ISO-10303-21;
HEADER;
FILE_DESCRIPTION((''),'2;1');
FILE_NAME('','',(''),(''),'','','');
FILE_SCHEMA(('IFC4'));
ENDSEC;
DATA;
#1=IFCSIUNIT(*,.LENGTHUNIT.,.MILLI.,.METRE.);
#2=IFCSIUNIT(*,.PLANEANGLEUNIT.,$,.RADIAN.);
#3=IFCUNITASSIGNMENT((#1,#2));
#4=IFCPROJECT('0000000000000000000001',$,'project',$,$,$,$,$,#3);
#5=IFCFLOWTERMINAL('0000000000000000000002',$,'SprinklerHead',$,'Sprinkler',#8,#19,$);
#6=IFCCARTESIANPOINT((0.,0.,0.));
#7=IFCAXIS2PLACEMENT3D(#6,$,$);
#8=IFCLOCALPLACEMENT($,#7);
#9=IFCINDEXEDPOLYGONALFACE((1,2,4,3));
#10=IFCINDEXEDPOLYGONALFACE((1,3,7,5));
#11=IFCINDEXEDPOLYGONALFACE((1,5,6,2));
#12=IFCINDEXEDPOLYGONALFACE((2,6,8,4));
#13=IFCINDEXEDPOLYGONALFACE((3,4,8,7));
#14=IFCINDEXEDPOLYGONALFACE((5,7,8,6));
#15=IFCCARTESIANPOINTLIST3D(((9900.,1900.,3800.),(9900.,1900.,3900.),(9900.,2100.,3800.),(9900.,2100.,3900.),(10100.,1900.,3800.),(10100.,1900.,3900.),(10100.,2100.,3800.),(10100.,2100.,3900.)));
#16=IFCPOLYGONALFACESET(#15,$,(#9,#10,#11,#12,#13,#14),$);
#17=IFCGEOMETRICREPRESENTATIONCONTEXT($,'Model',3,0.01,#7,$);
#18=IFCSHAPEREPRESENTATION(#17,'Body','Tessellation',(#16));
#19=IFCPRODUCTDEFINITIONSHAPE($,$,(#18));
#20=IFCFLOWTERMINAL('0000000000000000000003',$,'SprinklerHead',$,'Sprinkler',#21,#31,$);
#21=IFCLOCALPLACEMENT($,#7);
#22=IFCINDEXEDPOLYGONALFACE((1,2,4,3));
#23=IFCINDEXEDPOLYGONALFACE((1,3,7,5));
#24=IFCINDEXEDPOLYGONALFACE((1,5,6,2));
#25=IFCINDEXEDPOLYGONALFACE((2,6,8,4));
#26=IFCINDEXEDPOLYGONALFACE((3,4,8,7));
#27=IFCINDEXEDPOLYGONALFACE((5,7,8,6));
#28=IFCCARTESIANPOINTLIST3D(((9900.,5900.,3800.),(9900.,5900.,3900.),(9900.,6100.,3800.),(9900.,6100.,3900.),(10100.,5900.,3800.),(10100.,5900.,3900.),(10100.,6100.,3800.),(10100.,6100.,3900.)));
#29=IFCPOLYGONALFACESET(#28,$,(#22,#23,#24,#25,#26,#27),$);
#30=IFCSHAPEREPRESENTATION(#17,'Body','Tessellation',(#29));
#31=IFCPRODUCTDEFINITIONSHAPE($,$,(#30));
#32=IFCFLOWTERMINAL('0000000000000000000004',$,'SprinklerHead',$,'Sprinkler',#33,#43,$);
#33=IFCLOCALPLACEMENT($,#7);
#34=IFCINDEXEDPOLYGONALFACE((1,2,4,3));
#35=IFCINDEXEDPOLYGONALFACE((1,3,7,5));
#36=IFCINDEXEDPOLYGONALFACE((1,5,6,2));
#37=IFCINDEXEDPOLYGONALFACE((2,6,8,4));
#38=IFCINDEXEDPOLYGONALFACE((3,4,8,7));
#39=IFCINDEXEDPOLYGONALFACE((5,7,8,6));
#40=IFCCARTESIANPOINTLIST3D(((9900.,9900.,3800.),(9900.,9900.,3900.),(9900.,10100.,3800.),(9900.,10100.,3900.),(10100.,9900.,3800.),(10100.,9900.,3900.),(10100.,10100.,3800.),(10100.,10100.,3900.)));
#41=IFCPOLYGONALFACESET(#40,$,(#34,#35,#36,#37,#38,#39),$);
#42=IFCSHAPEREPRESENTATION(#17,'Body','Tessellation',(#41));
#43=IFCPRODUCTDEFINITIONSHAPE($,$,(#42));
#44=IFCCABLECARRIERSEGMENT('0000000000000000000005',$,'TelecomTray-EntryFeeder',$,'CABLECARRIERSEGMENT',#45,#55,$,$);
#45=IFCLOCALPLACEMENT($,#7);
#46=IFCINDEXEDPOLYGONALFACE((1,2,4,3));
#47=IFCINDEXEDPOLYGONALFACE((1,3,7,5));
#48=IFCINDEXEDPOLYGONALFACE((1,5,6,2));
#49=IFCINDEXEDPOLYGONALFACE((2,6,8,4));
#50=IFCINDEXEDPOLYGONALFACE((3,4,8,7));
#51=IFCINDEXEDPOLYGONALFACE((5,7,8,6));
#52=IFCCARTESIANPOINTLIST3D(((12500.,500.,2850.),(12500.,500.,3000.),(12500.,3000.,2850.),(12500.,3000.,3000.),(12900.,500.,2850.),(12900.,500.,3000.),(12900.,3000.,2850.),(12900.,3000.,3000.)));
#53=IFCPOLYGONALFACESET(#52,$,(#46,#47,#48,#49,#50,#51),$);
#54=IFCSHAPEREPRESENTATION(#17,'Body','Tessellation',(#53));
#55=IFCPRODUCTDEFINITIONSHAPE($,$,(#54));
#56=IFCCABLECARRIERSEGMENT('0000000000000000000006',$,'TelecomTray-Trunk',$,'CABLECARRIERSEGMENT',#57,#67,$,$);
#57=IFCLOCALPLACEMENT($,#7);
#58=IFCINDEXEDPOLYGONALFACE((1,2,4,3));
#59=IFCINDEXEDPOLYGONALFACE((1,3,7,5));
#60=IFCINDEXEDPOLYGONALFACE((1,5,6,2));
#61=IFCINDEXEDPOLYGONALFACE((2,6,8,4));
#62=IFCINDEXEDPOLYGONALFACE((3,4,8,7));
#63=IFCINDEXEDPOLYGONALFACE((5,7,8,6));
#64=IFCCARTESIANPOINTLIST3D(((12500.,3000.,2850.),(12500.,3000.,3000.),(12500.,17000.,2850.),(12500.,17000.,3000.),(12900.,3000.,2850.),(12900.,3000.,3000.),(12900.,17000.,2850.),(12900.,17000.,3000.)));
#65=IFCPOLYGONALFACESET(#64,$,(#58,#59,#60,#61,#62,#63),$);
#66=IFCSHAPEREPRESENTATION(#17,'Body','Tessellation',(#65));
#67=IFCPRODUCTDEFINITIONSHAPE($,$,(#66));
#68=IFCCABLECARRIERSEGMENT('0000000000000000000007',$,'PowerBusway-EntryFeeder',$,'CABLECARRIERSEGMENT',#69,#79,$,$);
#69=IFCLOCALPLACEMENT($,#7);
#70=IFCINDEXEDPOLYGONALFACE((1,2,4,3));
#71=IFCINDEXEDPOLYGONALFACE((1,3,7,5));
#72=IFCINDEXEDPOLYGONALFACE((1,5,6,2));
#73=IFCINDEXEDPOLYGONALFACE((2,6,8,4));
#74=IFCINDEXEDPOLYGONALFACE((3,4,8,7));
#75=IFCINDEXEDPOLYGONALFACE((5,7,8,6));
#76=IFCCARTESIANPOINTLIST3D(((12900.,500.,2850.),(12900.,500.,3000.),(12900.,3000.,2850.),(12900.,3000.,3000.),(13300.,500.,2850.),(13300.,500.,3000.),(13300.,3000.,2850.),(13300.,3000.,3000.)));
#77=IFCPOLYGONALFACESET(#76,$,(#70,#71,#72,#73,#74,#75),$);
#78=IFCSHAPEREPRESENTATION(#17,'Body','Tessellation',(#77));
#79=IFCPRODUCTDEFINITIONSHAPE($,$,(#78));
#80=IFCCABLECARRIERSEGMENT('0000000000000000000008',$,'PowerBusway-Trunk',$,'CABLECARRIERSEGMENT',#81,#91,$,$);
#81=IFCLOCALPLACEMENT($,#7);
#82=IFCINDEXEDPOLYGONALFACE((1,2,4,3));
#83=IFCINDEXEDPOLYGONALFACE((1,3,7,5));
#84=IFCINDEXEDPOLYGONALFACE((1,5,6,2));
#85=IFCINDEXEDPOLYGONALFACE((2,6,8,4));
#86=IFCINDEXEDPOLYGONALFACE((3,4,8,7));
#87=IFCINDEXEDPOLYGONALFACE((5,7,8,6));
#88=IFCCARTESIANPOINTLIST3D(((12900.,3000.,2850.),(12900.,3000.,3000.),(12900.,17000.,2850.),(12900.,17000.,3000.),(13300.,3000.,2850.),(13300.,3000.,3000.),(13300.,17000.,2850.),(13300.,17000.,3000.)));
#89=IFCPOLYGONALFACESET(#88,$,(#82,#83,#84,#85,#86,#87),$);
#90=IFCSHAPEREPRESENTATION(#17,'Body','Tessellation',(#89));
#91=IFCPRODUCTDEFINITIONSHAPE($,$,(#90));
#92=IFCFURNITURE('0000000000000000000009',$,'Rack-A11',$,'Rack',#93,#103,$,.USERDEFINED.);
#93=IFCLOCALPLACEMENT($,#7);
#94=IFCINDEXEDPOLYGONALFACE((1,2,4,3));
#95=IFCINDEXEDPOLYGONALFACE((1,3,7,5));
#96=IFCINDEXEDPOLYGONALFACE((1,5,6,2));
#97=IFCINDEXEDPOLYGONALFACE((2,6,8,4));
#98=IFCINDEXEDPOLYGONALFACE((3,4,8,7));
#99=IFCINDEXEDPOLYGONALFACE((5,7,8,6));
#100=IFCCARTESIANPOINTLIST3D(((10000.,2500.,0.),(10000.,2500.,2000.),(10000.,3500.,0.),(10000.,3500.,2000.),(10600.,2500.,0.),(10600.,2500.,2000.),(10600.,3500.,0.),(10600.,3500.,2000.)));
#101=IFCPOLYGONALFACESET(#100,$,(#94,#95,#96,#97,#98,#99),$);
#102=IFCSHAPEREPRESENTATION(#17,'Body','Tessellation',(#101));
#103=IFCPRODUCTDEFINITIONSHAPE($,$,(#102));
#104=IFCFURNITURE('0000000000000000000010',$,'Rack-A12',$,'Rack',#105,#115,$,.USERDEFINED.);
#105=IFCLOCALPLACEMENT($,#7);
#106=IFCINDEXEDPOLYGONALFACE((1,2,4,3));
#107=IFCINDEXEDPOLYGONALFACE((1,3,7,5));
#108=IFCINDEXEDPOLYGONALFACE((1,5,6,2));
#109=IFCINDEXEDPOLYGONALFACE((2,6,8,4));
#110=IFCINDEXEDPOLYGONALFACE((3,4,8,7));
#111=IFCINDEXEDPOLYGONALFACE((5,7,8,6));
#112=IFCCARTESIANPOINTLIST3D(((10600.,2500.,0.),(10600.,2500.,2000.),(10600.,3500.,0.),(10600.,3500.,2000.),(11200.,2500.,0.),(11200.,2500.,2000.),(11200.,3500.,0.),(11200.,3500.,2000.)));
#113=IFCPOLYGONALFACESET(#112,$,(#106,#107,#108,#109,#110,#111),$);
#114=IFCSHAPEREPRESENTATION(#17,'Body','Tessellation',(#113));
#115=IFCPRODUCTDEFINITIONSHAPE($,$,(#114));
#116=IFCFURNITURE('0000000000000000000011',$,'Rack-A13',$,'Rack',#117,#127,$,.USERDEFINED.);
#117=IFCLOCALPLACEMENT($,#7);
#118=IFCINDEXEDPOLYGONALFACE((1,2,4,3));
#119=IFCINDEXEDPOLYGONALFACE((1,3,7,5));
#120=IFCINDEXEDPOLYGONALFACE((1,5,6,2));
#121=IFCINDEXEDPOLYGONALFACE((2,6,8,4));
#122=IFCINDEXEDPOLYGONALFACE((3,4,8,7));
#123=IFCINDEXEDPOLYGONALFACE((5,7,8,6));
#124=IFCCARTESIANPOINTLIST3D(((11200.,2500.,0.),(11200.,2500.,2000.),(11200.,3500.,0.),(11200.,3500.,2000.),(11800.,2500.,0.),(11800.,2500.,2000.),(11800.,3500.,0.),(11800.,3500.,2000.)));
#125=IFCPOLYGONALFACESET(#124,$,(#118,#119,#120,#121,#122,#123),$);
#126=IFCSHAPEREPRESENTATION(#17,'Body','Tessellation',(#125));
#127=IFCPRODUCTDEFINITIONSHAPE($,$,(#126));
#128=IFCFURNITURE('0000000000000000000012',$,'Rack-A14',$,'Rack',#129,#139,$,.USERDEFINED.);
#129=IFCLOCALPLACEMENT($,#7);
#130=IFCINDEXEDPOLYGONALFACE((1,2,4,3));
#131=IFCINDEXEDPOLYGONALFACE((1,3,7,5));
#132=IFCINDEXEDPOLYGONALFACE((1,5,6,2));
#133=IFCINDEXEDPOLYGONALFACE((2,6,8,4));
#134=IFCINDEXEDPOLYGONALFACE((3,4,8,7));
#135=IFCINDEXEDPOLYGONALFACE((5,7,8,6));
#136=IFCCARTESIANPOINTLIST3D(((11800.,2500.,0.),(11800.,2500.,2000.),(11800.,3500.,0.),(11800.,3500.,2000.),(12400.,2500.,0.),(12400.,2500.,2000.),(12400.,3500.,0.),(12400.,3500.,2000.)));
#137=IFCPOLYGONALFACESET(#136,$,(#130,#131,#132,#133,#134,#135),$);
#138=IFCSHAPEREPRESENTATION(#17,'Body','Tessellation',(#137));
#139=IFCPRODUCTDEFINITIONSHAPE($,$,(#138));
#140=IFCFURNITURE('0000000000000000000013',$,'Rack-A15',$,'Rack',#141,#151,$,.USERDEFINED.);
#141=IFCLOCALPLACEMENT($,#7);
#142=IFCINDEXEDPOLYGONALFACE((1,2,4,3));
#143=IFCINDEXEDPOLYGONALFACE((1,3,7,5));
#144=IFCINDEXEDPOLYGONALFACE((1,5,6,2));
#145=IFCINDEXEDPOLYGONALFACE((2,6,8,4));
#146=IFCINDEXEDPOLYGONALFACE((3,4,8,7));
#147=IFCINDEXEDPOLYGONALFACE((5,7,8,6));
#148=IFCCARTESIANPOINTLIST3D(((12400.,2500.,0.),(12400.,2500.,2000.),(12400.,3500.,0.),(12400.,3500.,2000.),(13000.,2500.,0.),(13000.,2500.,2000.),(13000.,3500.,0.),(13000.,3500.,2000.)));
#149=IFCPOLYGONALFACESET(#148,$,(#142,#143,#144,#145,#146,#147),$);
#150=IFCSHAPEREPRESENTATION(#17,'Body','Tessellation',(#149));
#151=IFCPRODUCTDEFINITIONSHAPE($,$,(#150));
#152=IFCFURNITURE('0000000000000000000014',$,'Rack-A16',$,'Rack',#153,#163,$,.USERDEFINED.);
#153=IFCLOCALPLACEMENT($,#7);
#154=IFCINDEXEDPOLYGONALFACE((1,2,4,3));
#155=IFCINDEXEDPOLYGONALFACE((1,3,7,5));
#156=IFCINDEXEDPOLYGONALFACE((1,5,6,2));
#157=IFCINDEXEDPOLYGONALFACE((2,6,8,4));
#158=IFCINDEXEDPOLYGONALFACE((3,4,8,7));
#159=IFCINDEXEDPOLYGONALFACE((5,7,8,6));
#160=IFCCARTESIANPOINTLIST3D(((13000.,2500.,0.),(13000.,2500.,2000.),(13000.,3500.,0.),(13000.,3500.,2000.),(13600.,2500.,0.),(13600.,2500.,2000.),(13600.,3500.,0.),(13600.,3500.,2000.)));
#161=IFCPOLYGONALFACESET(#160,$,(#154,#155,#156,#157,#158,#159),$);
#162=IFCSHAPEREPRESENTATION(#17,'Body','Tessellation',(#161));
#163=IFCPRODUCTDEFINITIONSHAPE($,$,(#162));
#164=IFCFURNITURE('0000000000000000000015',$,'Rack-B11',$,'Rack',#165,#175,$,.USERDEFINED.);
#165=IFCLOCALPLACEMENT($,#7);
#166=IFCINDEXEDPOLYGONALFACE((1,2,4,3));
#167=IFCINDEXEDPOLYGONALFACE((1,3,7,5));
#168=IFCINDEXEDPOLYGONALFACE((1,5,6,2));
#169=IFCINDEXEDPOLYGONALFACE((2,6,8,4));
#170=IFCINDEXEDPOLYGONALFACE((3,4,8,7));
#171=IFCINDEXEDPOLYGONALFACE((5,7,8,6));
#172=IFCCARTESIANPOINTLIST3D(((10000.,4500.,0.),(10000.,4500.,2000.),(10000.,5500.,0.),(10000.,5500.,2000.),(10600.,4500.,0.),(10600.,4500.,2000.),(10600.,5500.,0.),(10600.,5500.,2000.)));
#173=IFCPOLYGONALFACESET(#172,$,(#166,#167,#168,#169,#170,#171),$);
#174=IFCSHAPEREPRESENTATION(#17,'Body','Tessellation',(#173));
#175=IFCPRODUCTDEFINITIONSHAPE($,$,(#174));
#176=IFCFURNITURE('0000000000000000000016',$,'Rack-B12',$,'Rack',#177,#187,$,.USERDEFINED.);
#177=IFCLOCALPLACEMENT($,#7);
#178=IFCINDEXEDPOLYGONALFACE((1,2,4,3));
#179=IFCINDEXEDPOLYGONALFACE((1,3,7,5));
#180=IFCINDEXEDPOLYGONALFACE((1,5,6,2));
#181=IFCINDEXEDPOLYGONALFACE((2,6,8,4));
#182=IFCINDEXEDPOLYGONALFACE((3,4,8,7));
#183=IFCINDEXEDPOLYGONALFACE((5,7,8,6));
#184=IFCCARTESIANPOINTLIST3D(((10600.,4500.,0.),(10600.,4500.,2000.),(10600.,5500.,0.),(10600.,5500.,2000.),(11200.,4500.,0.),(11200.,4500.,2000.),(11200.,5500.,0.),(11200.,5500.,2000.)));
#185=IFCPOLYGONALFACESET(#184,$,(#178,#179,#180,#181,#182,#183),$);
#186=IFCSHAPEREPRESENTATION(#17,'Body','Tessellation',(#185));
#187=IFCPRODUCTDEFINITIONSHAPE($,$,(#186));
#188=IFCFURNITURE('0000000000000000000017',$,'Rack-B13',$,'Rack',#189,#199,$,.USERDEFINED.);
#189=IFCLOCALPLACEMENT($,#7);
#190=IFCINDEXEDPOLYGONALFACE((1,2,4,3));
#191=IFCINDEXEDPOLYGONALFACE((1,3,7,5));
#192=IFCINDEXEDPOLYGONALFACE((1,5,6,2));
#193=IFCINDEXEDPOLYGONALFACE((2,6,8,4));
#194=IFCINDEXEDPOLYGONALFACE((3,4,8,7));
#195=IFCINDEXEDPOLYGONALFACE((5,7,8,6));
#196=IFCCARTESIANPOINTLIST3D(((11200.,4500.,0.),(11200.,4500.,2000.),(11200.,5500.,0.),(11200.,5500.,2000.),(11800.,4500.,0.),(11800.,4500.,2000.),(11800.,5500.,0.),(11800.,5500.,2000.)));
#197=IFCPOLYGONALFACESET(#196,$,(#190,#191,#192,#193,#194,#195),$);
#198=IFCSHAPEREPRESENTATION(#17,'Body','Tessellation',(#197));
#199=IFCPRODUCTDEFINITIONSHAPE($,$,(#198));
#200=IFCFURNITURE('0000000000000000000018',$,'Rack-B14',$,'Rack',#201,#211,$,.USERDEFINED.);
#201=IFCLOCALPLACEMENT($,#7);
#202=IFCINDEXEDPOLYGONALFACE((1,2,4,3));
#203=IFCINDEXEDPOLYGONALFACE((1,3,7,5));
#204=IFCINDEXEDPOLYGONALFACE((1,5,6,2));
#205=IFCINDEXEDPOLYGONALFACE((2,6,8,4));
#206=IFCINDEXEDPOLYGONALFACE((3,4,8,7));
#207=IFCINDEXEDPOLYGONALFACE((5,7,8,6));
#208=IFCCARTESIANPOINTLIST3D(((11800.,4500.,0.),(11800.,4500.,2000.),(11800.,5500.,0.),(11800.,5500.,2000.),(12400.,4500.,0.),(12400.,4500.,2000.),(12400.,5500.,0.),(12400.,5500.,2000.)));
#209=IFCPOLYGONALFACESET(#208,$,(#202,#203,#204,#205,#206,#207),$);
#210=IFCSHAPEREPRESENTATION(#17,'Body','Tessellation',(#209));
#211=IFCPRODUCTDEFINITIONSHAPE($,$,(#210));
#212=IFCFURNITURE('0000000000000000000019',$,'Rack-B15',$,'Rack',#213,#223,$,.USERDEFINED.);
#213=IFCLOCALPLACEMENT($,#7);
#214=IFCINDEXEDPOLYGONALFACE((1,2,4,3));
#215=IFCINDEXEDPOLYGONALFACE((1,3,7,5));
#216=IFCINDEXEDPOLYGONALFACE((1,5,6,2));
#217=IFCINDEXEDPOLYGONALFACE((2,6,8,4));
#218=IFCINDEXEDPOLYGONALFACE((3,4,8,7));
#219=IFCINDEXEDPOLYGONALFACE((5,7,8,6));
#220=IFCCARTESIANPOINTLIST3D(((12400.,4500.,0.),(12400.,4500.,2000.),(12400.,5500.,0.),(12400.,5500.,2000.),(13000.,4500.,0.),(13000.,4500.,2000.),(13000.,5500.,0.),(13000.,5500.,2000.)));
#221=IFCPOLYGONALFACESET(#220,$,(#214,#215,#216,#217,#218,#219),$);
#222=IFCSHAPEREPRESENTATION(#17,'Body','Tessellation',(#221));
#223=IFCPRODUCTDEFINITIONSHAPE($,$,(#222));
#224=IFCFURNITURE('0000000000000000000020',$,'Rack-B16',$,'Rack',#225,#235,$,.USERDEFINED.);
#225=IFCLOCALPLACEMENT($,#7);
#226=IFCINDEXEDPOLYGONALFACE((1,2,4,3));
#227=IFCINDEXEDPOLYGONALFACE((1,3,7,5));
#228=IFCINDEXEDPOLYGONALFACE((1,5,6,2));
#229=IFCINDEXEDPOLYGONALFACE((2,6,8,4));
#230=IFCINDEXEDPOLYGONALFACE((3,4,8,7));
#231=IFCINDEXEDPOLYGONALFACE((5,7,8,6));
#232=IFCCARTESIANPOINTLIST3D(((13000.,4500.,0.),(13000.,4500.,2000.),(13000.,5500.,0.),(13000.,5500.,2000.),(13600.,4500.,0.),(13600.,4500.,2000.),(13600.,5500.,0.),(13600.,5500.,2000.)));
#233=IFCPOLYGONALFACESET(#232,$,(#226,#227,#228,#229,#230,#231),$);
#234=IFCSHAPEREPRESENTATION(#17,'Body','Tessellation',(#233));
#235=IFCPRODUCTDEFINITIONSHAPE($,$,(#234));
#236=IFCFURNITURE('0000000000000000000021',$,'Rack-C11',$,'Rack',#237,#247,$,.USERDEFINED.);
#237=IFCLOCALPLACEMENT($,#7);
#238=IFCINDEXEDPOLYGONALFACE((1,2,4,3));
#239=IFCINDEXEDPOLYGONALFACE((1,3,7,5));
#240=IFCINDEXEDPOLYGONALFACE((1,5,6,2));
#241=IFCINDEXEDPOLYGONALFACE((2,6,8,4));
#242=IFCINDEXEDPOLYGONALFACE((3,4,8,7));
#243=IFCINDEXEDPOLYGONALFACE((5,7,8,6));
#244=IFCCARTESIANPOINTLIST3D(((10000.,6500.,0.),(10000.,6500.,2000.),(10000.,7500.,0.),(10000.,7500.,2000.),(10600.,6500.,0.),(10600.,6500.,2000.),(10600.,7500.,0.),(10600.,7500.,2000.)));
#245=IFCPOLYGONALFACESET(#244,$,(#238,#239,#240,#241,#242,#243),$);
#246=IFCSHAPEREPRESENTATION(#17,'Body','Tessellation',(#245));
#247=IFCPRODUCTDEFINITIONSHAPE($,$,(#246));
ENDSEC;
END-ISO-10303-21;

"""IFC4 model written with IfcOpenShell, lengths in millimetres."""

from ifc_helpers import new_model, si_unit, frame, origin, place, context, project, polyline, outline, extrude, element, save


model = new_model("IFC4")

# Units and contexts
model_context = context("Model", 3, precision=0.01, world=origin())
ifc_project = project(units=[si_unit("LENGTHUNIT", "METRE", prefix="MILLI"), si_unit("PLANEANGLEUNIT", "RADIAN")])

# Flow terminals
for number, where, name in (
    (1, (10000.0, 2000.0, 3800.0), "SprinklerHead"),
    (2, (10000.0, 6000.0, 3800.0), "SprinklerHead"),
    (3, (10000.0, 10000.0, 3800.0), "SprinklerHead"),
):
    element("IfcFlowTerminal", number, at=place(None, frame(where)), Name=name, ObjectType="Sprinkler", context=model_context, shape_type="SweptSolid", body=[
        extrude(outline(polyline([(-100.0, -100.0), (100.0, -100.0), (100.0, 100.0), (-100.0, 100.0), (-100.0, -100.0)])), origin(), (0.0, 0.0, 1.0), 100.0),
    ])

# Cable carrier segments
cable_carrier_segment_1_placement = place(None, frame((12700.0, 1750.0, 2850.0)))
element("IfcCableCarrierSegment", 4, at=cable_carrier_segment_1_placement, Name="TelecomTray-EntryFeeder", ObjectType="CABLECARRIERSEGMENT", context=model_context, shape_type="SweptSolid", body=[
    extrude(outline(polyline([(-200.0, -1250.0), (200.0, -1250.0), (200.0, 1250.0), (-200.0, 1250.0), (-200.0, -1250.0)])), origin(), (0.0, 0.0, 1.0), 150.0),
])
cable_carrier_segment_2_placement = place(None, frame((12700.0, 10000.0, 2850.0)))
element("IfcCableCarrierSegment", 5, at=cable_carrier_segment_2_placement, Name="TelecomTray-Trunk", ObjectType="CABLECARRIERSEGMENT", context=model_context, shape_type="SweptSolid", body=[
    extrude(outline(polyline([(-200.0, -7000.0), (200.0, -7000.0), (200.0, 7000.0), (-200.0, 7000.0), (-200.0, -7000.0)])), origin(), (0.0, 0.0, 1.0), 150.0),
])
cable_carrier_segment_3_placement = place(None, frame((13100.0, 1750.0, 2850.0)))
element("IfcCableCarrierSegment", 6, at=cable_carrier_segment_3_placement, Name="PowerBusway-EntryFeeder", ObjectType="CABLECARRIERSEGMENT", context=model_context, shape_type="SweptSolid", body=[
    extrude(outline(polyline([(-200.0, -1250.0), (200.0, -1250.0), (200.0, 1250.0), (-200.0, 1250.0), (-200.0, -1250.0)])), origin(), (0.0, 0.0, 1.0), 150.0),
])
cable_carrier_segment_4_placement = place(None, frame((13100.0, 10000.0, 2850.0)))
element("IfcCableCarrierSegment", 7, at=cable_carrier_segment_4_placement, Name="PowerBusway-Trunk", ObjectType="CABLECARRIERSEGMENT", context=model_context, shape_type="SweptSolid", body=[
    extrude(outline(polyline([(-200.0, -7000.0), (200.0, -7000.0), (200.0, 7000.0), (-200.0, 7000.0), (-200.0, -7000.0)])), origin(), (0.0, 0.0, 1.0), 150.0),
])

# Furniture
for number, where, name in (
    (8, (10300.0, 3000.0, 0.0), "Rack-A11"),
    (9, (10900.0, 3000.0, 0.0), "Rack-A12"),
    (10, (11500.0, 3000.0, 0.0), "Rack-A13"),
    (11, (12100.0, 3000.0, 0.0), "Rack-A14"),
    (12, (12700.0, 3000.0, 0.0), "Rack-A15"),
    (13, (13300.0, 3000.0, 0.0), "Rack-A16"),
    (14, (10300.0, 5000.0, 0.0), "Rack-B11"),
    (15, (10900.0, 5000.0, 0.0), "Rack-B12"),
    (16, (11500.0, 5000.0, 0.0), "Rack-B13"),
    (17, (12100.0, 5000.0, 0.0), "Rack-B14"),
    (18, (12700.0, 5000.0, 0.0), "Rack-B15"),
    (19, (13300.0, 5000.0, 0.0), "Rack-B16"),
    (20, (10300.0, 7000.0, 0.0), "Rack-C11"),
):
    element("IfcFurniture", number, at=place(None, frame(where)), Name=name, ObjectType="Rack", PredefinedType="USERDEFINED", context=model_context, shape_type="SweptSolid", body=[
        extrude(outline(polyline([(-300.0, -500.0), (300.0, -500.0), (300.0, 500.0), (-300.0, 500.0), (-300.0, -500.0)])), origin(), (0.0, 0.0, 1.0), 2000.0),
    ])

save(model, "model.ifc")
